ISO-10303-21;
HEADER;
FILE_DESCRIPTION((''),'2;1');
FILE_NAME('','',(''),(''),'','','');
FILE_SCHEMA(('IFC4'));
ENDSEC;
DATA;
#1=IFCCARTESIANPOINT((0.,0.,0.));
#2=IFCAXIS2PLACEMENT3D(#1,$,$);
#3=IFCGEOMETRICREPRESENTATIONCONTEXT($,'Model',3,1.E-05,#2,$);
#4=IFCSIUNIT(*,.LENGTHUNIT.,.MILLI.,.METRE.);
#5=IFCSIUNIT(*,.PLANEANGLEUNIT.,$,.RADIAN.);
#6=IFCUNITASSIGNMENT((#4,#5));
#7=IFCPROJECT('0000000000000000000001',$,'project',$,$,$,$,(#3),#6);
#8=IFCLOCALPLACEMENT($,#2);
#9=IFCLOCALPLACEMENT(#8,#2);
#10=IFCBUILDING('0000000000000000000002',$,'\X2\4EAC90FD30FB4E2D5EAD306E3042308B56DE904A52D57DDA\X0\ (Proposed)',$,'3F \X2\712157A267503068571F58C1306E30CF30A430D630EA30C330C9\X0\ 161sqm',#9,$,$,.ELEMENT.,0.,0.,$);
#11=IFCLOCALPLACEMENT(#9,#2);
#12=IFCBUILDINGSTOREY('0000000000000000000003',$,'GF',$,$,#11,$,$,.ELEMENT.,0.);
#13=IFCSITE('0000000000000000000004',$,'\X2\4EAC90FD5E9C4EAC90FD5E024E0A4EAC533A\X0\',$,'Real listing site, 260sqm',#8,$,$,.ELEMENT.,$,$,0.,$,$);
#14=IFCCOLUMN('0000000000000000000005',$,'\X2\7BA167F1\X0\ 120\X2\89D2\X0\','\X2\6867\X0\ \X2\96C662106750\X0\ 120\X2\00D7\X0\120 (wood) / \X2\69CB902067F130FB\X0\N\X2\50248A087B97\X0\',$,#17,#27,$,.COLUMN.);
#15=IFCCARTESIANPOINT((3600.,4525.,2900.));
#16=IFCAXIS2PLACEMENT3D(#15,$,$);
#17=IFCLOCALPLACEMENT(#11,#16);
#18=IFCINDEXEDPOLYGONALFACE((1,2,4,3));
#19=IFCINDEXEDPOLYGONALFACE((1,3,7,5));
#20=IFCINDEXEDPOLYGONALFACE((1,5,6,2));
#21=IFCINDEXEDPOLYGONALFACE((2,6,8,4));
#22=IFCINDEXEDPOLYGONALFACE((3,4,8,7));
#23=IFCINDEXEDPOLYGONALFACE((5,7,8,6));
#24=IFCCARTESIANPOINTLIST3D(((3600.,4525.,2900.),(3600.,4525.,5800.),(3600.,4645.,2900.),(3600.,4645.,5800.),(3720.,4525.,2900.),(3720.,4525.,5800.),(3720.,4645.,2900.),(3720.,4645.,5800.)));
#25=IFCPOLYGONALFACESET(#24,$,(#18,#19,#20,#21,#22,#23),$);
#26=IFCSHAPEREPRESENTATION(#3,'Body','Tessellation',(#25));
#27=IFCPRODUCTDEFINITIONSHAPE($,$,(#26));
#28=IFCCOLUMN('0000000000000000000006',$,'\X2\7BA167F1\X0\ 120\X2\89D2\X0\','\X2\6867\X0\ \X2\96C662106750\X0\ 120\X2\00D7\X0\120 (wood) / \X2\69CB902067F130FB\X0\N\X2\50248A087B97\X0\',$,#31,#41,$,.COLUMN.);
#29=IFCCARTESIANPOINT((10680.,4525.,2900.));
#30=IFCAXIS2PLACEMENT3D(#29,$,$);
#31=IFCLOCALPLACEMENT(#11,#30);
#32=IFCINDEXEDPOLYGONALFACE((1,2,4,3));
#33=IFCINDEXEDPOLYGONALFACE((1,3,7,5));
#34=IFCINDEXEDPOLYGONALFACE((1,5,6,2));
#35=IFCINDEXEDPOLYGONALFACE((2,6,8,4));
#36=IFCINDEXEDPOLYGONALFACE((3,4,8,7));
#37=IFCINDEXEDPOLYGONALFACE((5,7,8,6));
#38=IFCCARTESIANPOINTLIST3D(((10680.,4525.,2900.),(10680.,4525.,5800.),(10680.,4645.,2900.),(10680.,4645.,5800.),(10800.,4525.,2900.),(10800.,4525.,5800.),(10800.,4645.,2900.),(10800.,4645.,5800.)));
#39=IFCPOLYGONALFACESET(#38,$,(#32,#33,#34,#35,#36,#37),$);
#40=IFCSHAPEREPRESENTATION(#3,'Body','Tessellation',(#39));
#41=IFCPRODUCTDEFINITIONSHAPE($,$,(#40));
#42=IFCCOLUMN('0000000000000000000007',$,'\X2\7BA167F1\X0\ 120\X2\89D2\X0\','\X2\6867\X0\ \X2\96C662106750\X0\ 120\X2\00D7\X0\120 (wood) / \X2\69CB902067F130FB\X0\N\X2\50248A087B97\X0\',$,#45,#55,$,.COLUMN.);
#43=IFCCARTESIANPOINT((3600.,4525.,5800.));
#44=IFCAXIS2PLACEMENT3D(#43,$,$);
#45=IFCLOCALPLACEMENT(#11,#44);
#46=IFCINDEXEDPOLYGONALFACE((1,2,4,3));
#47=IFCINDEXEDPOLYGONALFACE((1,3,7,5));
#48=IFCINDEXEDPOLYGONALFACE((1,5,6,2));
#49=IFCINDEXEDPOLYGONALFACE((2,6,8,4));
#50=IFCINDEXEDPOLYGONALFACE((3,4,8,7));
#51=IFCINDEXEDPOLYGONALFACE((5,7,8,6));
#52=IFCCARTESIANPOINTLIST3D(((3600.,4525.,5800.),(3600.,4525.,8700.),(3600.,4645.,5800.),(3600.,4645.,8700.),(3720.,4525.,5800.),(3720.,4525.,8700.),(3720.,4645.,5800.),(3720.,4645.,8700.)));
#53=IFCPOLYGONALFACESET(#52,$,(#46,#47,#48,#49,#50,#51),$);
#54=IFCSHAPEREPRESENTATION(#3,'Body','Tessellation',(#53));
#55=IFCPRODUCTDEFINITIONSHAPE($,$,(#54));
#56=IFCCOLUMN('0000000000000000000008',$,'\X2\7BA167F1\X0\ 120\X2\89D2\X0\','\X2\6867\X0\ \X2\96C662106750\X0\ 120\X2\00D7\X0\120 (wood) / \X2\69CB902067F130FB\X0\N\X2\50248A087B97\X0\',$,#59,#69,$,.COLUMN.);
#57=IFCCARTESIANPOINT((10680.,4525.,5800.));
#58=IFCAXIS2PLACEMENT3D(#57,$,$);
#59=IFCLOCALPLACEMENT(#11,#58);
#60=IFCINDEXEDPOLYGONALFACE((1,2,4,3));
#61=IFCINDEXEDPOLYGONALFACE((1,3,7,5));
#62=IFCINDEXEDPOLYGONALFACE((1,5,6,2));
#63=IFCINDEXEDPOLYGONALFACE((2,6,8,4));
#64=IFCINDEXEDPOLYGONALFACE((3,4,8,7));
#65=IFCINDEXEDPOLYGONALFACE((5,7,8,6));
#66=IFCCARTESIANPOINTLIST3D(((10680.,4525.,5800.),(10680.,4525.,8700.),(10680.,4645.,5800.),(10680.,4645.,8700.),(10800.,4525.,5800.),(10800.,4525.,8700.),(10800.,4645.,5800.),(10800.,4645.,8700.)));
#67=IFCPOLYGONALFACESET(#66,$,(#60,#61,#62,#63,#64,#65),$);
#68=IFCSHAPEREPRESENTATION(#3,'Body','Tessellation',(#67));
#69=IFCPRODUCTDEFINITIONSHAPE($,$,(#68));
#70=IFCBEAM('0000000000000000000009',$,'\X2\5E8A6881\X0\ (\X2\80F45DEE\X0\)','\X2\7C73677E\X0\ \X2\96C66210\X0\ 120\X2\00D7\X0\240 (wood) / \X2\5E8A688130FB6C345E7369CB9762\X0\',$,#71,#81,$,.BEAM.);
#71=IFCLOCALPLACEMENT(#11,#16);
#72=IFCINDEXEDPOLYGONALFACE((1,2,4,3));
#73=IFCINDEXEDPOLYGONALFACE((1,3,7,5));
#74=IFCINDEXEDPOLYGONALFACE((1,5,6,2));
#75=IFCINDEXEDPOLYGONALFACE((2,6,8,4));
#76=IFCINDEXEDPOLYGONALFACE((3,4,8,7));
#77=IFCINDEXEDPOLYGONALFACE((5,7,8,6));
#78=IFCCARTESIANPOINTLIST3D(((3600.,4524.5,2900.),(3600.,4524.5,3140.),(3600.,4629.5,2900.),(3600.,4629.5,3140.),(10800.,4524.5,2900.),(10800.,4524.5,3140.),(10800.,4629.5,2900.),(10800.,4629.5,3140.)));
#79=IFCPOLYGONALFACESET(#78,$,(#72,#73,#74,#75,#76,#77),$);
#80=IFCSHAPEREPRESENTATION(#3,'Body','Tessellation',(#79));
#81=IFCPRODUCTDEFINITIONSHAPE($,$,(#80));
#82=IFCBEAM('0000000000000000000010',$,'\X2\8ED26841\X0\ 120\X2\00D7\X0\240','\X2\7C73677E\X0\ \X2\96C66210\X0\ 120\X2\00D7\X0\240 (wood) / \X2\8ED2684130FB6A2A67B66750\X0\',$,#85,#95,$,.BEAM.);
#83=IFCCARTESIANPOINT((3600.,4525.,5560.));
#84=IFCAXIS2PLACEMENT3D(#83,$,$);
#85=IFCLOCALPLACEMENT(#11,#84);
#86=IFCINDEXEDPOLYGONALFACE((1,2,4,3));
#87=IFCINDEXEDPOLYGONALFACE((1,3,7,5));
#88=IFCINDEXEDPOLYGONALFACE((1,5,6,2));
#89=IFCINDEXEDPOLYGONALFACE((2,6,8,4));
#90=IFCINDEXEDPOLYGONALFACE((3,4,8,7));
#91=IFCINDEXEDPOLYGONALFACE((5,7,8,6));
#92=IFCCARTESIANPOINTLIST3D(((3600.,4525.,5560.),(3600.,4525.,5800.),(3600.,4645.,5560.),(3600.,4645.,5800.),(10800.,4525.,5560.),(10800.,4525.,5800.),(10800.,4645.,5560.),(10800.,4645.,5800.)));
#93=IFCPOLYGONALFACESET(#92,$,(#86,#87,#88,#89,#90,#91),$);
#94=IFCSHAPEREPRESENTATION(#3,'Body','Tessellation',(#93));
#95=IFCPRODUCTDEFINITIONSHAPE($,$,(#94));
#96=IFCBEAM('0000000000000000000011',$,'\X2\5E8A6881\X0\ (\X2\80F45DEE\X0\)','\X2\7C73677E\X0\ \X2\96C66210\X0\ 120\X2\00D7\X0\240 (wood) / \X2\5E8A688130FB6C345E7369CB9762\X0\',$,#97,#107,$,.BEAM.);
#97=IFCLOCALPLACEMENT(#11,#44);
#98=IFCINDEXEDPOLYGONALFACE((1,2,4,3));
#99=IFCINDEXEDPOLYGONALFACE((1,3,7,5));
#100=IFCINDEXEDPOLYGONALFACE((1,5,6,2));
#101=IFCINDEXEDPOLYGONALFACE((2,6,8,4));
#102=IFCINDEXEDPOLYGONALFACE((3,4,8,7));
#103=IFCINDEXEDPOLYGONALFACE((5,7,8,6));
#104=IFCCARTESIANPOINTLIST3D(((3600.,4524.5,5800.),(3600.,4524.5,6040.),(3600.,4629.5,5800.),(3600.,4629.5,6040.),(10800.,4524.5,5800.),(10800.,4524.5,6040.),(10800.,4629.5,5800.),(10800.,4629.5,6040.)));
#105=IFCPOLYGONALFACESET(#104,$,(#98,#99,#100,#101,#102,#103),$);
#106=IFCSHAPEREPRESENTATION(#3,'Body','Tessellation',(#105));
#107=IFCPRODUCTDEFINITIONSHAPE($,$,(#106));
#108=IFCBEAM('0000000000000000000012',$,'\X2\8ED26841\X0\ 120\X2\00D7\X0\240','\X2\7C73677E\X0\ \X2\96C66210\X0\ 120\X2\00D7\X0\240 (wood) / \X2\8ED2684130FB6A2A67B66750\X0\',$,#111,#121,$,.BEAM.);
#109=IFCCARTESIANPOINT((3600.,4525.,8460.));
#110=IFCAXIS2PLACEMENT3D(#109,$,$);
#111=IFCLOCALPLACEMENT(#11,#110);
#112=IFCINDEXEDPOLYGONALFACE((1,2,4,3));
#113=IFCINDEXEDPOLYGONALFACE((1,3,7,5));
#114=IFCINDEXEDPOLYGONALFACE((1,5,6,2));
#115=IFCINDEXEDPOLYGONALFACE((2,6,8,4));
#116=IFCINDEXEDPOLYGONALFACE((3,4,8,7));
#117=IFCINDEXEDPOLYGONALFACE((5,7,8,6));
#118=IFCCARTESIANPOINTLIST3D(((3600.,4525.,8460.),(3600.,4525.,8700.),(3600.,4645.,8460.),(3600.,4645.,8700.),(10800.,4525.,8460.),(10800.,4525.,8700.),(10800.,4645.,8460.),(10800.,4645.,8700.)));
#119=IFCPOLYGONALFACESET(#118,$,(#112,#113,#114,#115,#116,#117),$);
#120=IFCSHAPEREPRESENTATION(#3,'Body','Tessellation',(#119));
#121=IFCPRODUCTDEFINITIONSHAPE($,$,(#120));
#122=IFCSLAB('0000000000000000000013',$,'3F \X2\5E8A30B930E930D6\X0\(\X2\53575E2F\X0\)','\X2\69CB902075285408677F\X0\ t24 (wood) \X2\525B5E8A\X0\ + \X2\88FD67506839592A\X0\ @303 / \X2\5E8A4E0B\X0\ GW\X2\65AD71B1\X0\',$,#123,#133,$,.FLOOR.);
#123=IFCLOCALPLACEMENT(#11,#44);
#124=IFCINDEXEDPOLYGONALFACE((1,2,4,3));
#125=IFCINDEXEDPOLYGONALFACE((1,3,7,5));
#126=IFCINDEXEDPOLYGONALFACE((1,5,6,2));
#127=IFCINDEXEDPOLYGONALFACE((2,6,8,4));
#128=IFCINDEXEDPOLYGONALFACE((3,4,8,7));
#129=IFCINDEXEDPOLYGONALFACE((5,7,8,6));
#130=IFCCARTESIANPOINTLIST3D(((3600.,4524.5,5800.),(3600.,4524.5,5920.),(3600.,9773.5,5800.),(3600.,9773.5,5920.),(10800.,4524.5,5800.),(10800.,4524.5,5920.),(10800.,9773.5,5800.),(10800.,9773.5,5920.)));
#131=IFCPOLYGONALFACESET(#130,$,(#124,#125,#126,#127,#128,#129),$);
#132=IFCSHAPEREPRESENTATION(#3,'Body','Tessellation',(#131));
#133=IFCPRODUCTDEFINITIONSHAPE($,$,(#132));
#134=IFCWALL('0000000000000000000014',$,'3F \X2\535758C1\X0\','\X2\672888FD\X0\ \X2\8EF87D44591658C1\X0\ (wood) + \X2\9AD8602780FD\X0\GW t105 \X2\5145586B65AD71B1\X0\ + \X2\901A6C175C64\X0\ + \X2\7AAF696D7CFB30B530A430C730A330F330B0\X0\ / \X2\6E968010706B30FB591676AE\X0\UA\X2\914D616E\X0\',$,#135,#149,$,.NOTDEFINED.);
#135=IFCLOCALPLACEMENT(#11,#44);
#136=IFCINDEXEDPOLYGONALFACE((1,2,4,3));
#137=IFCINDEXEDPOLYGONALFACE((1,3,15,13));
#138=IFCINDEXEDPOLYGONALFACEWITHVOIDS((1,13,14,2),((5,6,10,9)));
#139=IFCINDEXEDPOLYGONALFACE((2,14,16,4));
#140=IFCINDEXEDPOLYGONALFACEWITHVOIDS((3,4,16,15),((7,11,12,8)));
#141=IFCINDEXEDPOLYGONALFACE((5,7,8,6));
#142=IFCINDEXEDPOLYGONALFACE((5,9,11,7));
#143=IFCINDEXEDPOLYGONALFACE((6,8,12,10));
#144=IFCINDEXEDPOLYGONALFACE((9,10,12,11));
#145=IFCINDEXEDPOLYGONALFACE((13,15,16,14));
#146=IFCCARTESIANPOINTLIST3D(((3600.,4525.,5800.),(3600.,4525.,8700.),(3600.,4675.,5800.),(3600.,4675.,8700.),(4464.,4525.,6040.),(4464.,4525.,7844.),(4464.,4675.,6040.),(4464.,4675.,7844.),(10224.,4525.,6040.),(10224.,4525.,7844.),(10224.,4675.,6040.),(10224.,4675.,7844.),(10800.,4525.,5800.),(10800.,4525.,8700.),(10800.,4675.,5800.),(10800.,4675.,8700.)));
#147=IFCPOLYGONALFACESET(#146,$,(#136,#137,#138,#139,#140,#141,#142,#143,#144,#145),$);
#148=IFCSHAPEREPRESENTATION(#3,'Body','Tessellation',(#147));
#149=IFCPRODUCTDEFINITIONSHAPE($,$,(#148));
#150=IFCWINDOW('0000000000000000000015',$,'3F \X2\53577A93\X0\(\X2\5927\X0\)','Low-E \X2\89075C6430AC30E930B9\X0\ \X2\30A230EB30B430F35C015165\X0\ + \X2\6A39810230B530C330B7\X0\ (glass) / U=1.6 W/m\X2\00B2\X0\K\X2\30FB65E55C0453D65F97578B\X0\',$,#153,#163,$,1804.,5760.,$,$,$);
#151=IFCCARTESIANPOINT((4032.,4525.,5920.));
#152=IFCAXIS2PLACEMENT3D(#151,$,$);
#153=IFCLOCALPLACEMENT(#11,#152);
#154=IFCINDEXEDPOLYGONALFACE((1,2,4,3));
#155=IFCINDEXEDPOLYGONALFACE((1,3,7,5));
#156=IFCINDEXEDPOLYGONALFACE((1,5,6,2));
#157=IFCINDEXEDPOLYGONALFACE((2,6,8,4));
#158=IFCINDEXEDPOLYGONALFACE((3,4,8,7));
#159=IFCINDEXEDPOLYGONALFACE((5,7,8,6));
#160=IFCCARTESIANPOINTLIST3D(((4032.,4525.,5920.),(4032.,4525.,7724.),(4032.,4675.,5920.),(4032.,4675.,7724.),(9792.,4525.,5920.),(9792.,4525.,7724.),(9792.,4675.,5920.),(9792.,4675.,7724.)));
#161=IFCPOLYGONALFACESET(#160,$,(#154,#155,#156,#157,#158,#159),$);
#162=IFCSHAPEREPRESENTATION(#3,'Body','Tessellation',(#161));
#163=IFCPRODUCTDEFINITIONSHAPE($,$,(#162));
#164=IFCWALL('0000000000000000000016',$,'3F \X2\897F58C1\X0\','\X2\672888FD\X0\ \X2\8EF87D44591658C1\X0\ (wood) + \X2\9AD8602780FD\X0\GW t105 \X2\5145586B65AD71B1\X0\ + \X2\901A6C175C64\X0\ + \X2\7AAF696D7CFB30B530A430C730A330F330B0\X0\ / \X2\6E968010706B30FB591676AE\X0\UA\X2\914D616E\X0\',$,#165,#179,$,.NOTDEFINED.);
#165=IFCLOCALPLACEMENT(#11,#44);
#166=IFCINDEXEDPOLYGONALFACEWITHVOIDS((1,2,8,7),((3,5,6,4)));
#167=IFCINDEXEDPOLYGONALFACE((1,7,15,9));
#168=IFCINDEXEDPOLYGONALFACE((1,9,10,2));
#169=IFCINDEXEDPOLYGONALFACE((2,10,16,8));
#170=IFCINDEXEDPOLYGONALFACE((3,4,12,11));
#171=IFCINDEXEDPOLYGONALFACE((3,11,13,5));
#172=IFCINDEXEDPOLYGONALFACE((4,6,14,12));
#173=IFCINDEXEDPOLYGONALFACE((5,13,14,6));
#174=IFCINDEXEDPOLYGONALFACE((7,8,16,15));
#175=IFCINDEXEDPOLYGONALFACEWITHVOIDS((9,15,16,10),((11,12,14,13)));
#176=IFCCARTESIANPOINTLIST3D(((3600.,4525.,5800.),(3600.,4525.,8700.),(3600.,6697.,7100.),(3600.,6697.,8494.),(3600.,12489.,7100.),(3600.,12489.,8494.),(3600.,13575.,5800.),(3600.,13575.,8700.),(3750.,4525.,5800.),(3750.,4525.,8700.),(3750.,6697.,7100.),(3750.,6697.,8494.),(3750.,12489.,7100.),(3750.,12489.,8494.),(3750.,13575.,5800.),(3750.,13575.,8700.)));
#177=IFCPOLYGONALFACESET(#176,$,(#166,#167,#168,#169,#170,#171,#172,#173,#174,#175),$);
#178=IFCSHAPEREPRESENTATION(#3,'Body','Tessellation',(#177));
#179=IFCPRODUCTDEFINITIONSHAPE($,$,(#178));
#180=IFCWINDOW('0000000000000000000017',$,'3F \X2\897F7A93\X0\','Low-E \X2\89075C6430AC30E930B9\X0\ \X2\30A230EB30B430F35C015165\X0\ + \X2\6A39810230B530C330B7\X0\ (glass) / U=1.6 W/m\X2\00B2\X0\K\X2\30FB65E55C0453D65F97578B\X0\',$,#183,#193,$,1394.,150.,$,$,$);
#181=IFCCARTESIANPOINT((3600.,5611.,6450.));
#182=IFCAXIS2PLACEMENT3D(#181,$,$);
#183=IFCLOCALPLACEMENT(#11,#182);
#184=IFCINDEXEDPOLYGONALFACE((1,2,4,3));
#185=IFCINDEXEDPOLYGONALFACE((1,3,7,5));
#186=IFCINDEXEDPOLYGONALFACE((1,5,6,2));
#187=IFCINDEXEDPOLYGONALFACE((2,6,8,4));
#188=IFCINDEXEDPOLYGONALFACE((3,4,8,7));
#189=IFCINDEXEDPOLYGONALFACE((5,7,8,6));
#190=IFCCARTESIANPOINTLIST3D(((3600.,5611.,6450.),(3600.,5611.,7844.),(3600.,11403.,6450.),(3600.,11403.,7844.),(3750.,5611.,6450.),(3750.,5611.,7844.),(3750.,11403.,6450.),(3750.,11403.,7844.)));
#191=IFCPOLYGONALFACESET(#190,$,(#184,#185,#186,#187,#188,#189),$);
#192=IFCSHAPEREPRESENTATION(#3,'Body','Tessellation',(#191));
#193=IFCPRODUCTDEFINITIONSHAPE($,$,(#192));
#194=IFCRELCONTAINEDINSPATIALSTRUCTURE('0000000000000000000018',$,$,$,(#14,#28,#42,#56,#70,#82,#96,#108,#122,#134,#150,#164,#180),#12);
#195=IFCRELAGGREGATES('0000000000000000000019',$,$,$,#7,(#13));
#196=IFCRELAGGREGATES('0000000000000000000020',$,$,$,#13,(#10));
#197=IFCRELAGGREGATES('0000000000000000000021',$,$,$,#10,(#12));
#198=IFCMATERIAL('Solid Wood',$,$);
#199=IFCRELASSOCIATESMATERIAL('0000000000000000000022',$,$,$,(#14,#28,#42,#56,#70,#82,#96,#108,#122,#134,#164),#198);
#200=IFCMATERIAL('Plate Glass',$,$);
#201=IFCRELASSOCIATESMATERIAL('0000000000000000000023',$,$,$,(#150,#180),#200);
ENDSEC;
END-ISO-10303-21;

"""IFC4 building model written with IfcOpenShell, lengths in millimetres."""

from ifc_helpers import new_model, si_unit, frame, frame_2d, origin, place, context, project, spatial, rectangle, extrude, material, element, fill, save


model = new_model("IFC4")

# Units and contexts
model_context = context("Model", 3, precision=1e-05, world=origin())
ifc_project = project(units=[si_unit("LENGTHUNIT", "METRE", prefix="MILLI"), si_unit("PLANEANGLEUNIT", "RADIAN")], contexts=[model_context])

# Site, building, storey
site_placement = place(None, origin())
site = spatial("IfcSite", under=ifc_project, at=site_placement, Name="京都府京都市上京区", ObjectType="Real listing site, 260sqm", CompositionType="ELEMENT", RefElevation=0.0)
building_placement = place(site_placement, origin())
building = spatial("IfcBuilding", under=site, at=building_placement, Name="京都・中庭のある回遊動線 (Proposed)", ObjectType="3F 無垢材と土壁のハイブリッド 161sqm", CompositionType="ELEMENT", ElevationOfRefHeight=0.0, ElevationOfTerrain=0.0)
storey_placement = place(building_placement, origin())
storey = spatial("IfcBuildingStorey", under=building, at=storey_placement, Name="GF", CompositionType="ELEMENT", Elevation=0.0)

# Columns
ifc_material_1 = material(Name="Solid Wood")
column_1_placement = place(storey_placement, frame((3600.0, 4525.0, 2900.0)))
element("IfcColumn", 1, at=column_1_placement, inside=storey, material=ifc_material_1, Name="管柱 120角", Description="桧 集成材 120×120 (wood) / 構造柱・N値計算", PredefinedType="COLUMN", context=model_context, shape_type="SweptSolid", body=[
    extrude(rectangle(XDim=120.0, YDim=120.0, at=frame_2d((60.0, 60.0))), frame((3600.0, 4525.0, 2900.0)), (0.0, 0.0, 1.0), 2900.0),
])
column_2_placement = place(storey_placement, frame((10680.0, 4525.0, 2900.0)))
element("IfcColumn", 2, at=column_2_placement, inside=storey, material=ifc_material_1, Name="管柱 120角", Description="桧 集成材 120×120 (wood) / 構造柱・N値計算", PredefinedType="COLUMN", context=model_context, shape_type="SweptSolid", body=[
    extrude(rectangle(XDim=120.0, YDim=120.0, at=frame_2d((60.0, 60.0))), frame((10680.0, 4525.0, 2900.0)), (0.0, 0.0, 1.0), 2900.0),
])
column_3_placement = place(storey_placement, frame((3600.0, 4525.0, 5800.0)))
element("IfcColumn", 3, at=column_3_placement, inside=storey, material=ifc_material_1, Name="管柱 120角", Description="桧 集成材 120×120 (wood) / 構造柱・N値計算", PredefinedType="COLUMN", context=model_context, shape_type="SweptSolid", body=[
    extrude(rectangle(XDim=120.0, YDim=120.0, at=frame_2d((60.0, 60.0))), frame((3600.0, 4525.0, 5800.0)), (0.0, 0.0, 1.0), 2900.0),
])
column_4_placement = place(storey_placement, frame((10680.0, 4525.0, 5800.0)))
element("IfcColumn", 4, at=column_4_placement, inside=storey, material=ifc_material_1, Name="管柱 120角", Description="桧 集成材 120×120 (wood) / 構造柱・N値計算", PredefinedType="COLUMN", context=model_context, shape_type="SweptSolid", body=[
    extrude(rectangle(XDim=120.0, YDim=120.0, at=frame_2d((60.0, 60.0))), frame((10680.0, 4525.0, 5800.0)), (0.0, 0.0, 1.0), 2900.0),
])

# Beams
beam_1_placement = place(storey_placement, frame((3600.0, 4525.0, 2900.0)))
element("IfcBeam", 5, at=beam_1_placement, inside=storey, material=ifc_material_1, Name="床梁 (胴差)", Description="米松 集成 120×240 (wood) / 床梁・水平構面", PredefinedType="BEAM", context=model_context, shape_type="SweptSolid", body=[
    extrude(rectangle(XDim=7200.0, YDim=105.0, at=frame_2d((3600.0, 52.0))), frame((3600.0, 4525.0, 2900.0)), (0.0, 0.0, 1.0), 240.0),
])
beam_2_placement = place(storey_placement, frame((3600.0, 4525.0, 5560.0)))
element("IfcBeam", 6, at=beam_2_placement, inside=storey, material=ifc_material_1, Name="軒桁 120×240", Description="米松 集成 120×240 (wood) / 軒桁・横架材", PredefinedType="BEAM", context=model_context, shape_type="SweptSolid", body=[
    extrude(rectangle(XDim=7200.0, YDim=120.0, at=frame_2d((3600.0, 60.0))), frame((3600.0, 4525.0, 5560.0)), (0.0, 0.0, 1.0), 240.0),
])
beam_3_placement = place(storey_placement, frame((3600.0, 4525.0, 5800.0)))
element("IfcBeam", 7, at=beam_3_placement, inside=storey, material=ifc_material_1, Name="床梁 (胴差)", Description="米松 集成 120×240 (wood) / 床梁・水平構面", PredefinedType="BEAM", context=model_context, shape_type="SweptSolid", body=[
    extrude(rectangle(XDim=7200.0, YDim=105.0, at=frame_2d((3600.0, 52.0))), frame((3600.0, 4525.0, 5800.0)), (0.0, 0.0, 1.0), 240.0),
])
beam_4_placement = place(storey_placement, frame((3600.0, 4525.0, 8460.0)))
element("IfcBeam", 8, at=beam_4_placement, inside=storey, material=ifc_material_1, Name="軒桁 120×240", Description="米松 集成 120×240 (wood) / 軒桁・横架材", PredefinedType="BEAM", context=model_context, shape_type="SweptSolid", body=[
    extrude(rectangle(XDim=7200.0, YDim=120.0, at=frame_2d((3600.0, 60.0))), frame((3600.0, 4525.0, 8460.0)), (0.0, 0.0, 1.0), 240.0),
])

# Slab
slab_placement = place(storey_placement, frame((3600.0, 4525.0, 5800.0)))
element("IfcSlab", 9, at=slab_placement, inside=storey, material=ifc_material_1, Name="3F 床スラブ(南帯)", Description="構造用合板 t24 (wood) 剛床 + 製材根太 @303 / 床下 GW断熱", PredefinedType="FLOOR", context=model_context, shape_type="SweptSolid", body=[
    extrude(rectangle(XDim=7200.0, YDim=5249.0, at=frame_2d((3600.0, 2624.0))), frame((3600.0, 4525.0, 5800.0)), (0.0, 0.0, 1.0), 120.0),
])

# Walls, openings, windows
wall_1_placement = place(storey_placement, frame((3600.0, 4525.0, 5800.0)))
wall_1 = element("IfcWall", 10, at=wall_1_placement, inside=storey, material=ifc_material_1, Name="3F 南壁", Description="木製 軸組外壁 (wood) + 高性能GW t105 充填断熱 + 通気層 + 窯業系サイディング / 準耐火・外皮UA配慮", PredefinedType="NOTDEFINED", context=model_context, shape_type="SweptSolid", body=[
    extrude(rectangle(XDim=7200.0, YDim=150.0, at=frame_2d((3600.0, 75.0))), frame((3600.0, 4525.0, 5800.0)), (0.0, 0.0, 1.0), 2900.0),
])
opening_1_placement = place(storey_placement, frame((4032.0, 4525.0, 5920.0)))
opening_1 = element("IfcOpeningElement", 11, at=opening_1_placement, cuts=wall_1, PredefinedType="NOTDEFINED", context=model_context, shape_type="SweptSolid", body=[
    extrude(rectangle(XDim=5760.0, YDim=150.0, at=frame_2d((2880.0, 75.0))), frame((4032.0, 4525.0, 5920.0)), (0.0, 0.0, 1.0), 1804.0),
])
ifc_material_2 = material(Name="Plate Glass")
window_1_placement = place(storey_placement, frame((4032.0, 4525.0, 5920.0)))
window_1 = element("IfcWindow", 12, at=window_1_placement, inside=storey, material=ifc_material_2, Name="3F 南窓(大)", Description="Low-E 複層ガラス アルゴン封入 + 樹脂サッシ (glass) / U=1.6 W/m²K・日射取得型", OverallHeight=1804.0, OverallWidth=5760.0, context=model_context, shape_type="SweptSolid", body=[
    extrude(rectangle(XDim=5760.0, YDim=150.0, at=frame_2d((2880.0, 75.0))), frame((4032.0, 4525.0, 5920.0)), (0.0, 0.0, 1.0), 1804.0),
])
fill(opening_1, window_1)
wall_2_placement = place(storey_placement, frame((3600.0, 4525.0, 5800.0)))
wall_2 = element("IfcWall", 13, at=wall_2_placement, inside=storey, material=ifc_material_1, Name="3F 西壁", Description="木製 軸組外壁 (wood) + 高性能GW t105 充填断熱 + 通気層 + 窯業系サイディング / 準耐火・外皮UA配慮", PredefinedType="NOTDEFINED", context=model_context, shape_type="SweptSolid", body=[
    extrude(rectangle(XDim=150.0, YDim=9050.0, at=frame_2d((75.0, 4525.0))), frame((3600.0, 4525.0, 5800.0)), (0.0, 0.0, 1.0), 2900.0),
])
opening_2_placement = place(storey_placement, frame((3600.0, 5611.0, 6450.0)))
opening_2 = element("IfcOpeningElement", 14, at=opening_2_placement, cuts=wall_2, PredefinedType="NOTDEFINED", context=model_context, shape_type="SweptSolid", body=[
    extrude(rectangle(XDim=150.0, YDim=5792.0, at=frame_2d((75.0, 2896.0))), frame((3600.0, 5611.0, 6450.0)), (0.0, 0.0, 1.0), 1394.0),
])
window_2_placement = place(storey_placement, frame((3600.0, 5611.0, 6450.0)))
window_2 = element("IfcWindow", 15, at=window_2_placement, inside=storey, material=ifc_material_2, Name="3F 西窓", Description="Low-E 複層ガラス アルゴン封入 + 樹脂サッシ (glass) / U=1.6 W/m²K・日射取得型", OverallHeight=1394.0, OverallWidth=150.0, context=model_context, shape_type="SweptSolid", body=[
    extrude(rectangle(XDim=150.0, YDim=5792.0, at=frame_2d((75.0, 2896.0))), frame((3600.0, 5611.0, 6450.0)), (0.0, 0.0, 1.0), 1394.0),
])
fill(opening_2, window_2)

save(model, "model.ifc")
